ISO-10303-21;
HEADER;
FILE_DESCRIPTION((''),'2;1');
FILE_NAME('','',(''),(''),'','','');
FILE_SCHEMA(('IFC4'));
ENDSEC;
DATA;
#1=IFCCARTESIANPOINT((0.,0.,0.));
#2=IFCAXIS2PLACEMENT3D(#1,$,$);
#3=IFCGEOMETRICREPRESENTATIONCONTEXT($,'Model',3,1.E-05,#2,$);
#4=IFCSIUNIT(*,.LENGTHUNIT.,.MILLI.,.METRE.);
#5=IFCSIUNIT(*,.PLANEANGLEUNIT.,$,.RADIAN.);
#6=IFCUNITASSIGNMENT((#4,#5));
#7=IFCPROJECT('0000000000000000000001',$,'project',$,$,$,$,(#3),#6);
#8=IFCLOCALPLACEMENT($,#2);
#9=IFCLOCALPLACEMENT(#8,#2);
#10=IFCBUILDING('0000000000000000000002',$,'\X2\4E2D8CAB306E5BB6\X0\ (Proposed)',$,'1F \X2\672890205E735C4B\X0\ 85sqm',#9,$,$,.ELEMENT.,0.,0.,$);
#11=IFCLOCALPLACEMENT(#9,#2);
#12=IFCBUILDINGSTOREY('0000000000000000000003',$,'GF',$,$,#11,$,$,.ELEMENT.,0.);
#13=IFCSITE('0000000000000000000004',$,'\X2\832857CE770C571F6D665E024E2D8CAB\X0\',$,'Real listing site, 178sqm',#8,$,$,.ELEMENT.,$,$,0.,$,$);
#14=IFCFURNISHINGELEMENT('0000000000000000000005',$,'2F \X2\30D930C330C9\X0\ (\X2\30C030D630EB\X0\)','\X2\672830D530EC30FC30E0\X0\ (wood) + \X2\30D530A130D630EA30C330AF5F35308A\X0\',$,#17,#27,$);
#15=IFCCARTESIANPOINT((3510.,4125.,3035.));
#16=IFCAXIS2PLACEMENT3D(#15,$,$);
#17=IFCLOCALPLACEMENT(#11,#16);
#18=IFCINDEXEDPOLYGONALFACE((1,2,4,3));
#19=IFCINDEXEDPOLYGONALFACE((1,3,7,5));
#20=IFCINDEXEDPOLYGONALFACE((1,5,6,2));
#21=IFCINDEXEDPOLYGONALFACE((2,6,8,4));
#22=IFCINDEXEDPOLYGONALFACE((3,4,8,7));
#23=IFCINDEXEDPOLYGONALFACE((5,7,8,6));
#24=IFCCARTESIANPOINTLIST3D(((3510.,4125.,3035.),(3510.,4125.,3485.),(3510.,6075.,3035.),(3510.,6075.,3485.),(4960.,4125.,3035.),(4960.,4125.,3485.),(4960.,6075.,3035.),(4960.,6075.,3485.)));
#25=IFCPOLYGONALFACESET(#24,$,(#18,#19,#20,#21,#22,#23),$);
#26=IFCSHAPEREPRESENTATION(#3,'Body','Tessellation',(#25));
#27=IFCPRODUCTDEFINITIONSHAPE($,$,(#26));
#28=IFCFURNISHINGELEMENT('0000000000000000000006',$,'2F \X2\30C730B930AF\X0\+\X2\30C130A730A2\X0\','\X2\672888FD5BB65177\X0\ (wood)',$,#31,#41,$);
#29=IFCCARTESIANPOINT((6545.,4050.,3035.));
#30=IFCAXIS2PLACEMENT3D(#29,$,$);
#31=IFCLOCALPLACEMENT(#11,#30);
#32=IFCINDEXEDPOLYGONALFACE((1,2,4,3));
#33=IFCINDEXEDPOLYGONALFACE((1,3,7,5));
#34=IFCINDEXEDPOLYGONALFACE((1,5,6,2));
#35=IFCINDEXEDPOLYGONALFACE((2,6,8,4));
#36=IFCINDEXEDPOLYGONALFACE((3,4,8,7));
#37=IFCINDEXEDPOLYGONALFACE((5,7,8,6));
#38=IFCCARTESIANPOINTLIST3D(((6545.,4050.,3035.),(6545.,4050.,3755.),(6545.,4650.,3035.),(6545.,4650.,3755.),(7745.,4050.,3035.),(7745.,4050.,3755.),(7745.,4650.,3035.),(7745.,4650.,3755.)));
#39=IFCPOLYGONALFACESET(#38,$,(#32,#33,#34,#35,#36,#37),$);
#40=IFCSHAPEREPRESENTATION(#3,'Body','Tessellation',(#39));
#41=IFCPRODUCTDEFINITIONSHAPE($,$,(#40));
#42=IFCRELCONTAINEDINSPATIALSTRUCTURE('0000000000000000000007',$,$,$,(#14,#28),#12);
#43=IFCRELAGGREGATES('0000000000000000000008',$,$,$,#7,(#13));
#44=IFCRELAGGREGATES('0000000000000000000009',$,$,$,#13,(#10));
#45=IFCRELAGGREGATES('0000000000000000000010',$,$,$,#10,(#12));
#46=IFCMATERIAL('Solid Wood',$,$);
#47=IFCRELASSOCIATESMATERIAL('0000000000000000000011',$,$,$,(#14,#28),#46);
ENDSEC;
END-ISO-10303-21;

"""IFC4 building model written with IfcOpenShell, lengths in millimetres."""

from ifc_helpers import new_model, si_unit, frame, frame_2d, origin, place, context, project, spatial, rectangle, extrude, material, element, save


model = new_model("IFC4")

# Units and contexts
model_context = context("Model", 3, precision=1e-05, world=origin())
ifc_project = project(units=[si_unit("LENGTHUNIT", "METRE", prefix="MILLI"), si_unit("PLANEANGLEUNIT", "RADIAN")], contexts=[model_context])

# Site, building, storey
site_placement = place(None, origin())
site = spatial("IfcSite", under=ifc_project, at=site_placement, Name="茨城県土浦市中貫", ObjectType="Real listing site, 178sqm", CompositionType="ELEMENT", RefElevation=0.0)
building_placement = place(site_placement, origin())
building = spatial("IfcBuilding", under=site, at=building_placement, Name="中貫の家 (Proposed)", ObjectType="1F 木造平屋 85sqm", CompositionType="ELEMENT", ElevationOfRefHeight=0.0, ElevationOfTerrain=0.0)
storey_placement = place(building_placement, origin())
storey = spatial("IfcBuildingStorey", under=building, at=storey_placement, Name="GF", CompositionType="ELEMENT", Elevation=0.0)

# Shared definitions
ifc_material_1 = material(Name="Solid Wood")

# Furnishing elements
furnishing_1_placement = place(storey_placement, frame((3510.0, 4125.0, 3035.0)))
element("IfcFurnishingElement", 1, at=furnishing_1_placement, inside=storey, material=ifc_material_1, Name="2F ベッド (ダブル)", Description="木フレーム (wood) + ファブリック張り", context=model_context, shape_type="SweptSolid", body=[
    extrude(rectangle(XDim=1450.0, YDim=1950.0, at=frame_2d((725.0, 975.0))), frame((3510.0, 4125.0, 3035.0)), (0.0, 0.0, 1.0), 450.0),
])
furnishing_2_placement = place(storey_placement, frame((6545.0, 4050.0, 3035.0)))
element("IfcFurnishingElement", 2, at=furnishing_2_placement, inside=storey, material=ifc_material_1, Name="2F デスク+チェア", Description="木製家具 (wood)", context=model_context, shape_type="SweptSolid", body=[
    extrude(rectangle(XDim=1200.0, YDim=600.0, at=frame_2d((600.0, 300.0))), frame((6545.0, 4050.0, 3035.0)), (0.0, 0.0, 1.0), 720.0),
])

save(model, "model.ifc")
